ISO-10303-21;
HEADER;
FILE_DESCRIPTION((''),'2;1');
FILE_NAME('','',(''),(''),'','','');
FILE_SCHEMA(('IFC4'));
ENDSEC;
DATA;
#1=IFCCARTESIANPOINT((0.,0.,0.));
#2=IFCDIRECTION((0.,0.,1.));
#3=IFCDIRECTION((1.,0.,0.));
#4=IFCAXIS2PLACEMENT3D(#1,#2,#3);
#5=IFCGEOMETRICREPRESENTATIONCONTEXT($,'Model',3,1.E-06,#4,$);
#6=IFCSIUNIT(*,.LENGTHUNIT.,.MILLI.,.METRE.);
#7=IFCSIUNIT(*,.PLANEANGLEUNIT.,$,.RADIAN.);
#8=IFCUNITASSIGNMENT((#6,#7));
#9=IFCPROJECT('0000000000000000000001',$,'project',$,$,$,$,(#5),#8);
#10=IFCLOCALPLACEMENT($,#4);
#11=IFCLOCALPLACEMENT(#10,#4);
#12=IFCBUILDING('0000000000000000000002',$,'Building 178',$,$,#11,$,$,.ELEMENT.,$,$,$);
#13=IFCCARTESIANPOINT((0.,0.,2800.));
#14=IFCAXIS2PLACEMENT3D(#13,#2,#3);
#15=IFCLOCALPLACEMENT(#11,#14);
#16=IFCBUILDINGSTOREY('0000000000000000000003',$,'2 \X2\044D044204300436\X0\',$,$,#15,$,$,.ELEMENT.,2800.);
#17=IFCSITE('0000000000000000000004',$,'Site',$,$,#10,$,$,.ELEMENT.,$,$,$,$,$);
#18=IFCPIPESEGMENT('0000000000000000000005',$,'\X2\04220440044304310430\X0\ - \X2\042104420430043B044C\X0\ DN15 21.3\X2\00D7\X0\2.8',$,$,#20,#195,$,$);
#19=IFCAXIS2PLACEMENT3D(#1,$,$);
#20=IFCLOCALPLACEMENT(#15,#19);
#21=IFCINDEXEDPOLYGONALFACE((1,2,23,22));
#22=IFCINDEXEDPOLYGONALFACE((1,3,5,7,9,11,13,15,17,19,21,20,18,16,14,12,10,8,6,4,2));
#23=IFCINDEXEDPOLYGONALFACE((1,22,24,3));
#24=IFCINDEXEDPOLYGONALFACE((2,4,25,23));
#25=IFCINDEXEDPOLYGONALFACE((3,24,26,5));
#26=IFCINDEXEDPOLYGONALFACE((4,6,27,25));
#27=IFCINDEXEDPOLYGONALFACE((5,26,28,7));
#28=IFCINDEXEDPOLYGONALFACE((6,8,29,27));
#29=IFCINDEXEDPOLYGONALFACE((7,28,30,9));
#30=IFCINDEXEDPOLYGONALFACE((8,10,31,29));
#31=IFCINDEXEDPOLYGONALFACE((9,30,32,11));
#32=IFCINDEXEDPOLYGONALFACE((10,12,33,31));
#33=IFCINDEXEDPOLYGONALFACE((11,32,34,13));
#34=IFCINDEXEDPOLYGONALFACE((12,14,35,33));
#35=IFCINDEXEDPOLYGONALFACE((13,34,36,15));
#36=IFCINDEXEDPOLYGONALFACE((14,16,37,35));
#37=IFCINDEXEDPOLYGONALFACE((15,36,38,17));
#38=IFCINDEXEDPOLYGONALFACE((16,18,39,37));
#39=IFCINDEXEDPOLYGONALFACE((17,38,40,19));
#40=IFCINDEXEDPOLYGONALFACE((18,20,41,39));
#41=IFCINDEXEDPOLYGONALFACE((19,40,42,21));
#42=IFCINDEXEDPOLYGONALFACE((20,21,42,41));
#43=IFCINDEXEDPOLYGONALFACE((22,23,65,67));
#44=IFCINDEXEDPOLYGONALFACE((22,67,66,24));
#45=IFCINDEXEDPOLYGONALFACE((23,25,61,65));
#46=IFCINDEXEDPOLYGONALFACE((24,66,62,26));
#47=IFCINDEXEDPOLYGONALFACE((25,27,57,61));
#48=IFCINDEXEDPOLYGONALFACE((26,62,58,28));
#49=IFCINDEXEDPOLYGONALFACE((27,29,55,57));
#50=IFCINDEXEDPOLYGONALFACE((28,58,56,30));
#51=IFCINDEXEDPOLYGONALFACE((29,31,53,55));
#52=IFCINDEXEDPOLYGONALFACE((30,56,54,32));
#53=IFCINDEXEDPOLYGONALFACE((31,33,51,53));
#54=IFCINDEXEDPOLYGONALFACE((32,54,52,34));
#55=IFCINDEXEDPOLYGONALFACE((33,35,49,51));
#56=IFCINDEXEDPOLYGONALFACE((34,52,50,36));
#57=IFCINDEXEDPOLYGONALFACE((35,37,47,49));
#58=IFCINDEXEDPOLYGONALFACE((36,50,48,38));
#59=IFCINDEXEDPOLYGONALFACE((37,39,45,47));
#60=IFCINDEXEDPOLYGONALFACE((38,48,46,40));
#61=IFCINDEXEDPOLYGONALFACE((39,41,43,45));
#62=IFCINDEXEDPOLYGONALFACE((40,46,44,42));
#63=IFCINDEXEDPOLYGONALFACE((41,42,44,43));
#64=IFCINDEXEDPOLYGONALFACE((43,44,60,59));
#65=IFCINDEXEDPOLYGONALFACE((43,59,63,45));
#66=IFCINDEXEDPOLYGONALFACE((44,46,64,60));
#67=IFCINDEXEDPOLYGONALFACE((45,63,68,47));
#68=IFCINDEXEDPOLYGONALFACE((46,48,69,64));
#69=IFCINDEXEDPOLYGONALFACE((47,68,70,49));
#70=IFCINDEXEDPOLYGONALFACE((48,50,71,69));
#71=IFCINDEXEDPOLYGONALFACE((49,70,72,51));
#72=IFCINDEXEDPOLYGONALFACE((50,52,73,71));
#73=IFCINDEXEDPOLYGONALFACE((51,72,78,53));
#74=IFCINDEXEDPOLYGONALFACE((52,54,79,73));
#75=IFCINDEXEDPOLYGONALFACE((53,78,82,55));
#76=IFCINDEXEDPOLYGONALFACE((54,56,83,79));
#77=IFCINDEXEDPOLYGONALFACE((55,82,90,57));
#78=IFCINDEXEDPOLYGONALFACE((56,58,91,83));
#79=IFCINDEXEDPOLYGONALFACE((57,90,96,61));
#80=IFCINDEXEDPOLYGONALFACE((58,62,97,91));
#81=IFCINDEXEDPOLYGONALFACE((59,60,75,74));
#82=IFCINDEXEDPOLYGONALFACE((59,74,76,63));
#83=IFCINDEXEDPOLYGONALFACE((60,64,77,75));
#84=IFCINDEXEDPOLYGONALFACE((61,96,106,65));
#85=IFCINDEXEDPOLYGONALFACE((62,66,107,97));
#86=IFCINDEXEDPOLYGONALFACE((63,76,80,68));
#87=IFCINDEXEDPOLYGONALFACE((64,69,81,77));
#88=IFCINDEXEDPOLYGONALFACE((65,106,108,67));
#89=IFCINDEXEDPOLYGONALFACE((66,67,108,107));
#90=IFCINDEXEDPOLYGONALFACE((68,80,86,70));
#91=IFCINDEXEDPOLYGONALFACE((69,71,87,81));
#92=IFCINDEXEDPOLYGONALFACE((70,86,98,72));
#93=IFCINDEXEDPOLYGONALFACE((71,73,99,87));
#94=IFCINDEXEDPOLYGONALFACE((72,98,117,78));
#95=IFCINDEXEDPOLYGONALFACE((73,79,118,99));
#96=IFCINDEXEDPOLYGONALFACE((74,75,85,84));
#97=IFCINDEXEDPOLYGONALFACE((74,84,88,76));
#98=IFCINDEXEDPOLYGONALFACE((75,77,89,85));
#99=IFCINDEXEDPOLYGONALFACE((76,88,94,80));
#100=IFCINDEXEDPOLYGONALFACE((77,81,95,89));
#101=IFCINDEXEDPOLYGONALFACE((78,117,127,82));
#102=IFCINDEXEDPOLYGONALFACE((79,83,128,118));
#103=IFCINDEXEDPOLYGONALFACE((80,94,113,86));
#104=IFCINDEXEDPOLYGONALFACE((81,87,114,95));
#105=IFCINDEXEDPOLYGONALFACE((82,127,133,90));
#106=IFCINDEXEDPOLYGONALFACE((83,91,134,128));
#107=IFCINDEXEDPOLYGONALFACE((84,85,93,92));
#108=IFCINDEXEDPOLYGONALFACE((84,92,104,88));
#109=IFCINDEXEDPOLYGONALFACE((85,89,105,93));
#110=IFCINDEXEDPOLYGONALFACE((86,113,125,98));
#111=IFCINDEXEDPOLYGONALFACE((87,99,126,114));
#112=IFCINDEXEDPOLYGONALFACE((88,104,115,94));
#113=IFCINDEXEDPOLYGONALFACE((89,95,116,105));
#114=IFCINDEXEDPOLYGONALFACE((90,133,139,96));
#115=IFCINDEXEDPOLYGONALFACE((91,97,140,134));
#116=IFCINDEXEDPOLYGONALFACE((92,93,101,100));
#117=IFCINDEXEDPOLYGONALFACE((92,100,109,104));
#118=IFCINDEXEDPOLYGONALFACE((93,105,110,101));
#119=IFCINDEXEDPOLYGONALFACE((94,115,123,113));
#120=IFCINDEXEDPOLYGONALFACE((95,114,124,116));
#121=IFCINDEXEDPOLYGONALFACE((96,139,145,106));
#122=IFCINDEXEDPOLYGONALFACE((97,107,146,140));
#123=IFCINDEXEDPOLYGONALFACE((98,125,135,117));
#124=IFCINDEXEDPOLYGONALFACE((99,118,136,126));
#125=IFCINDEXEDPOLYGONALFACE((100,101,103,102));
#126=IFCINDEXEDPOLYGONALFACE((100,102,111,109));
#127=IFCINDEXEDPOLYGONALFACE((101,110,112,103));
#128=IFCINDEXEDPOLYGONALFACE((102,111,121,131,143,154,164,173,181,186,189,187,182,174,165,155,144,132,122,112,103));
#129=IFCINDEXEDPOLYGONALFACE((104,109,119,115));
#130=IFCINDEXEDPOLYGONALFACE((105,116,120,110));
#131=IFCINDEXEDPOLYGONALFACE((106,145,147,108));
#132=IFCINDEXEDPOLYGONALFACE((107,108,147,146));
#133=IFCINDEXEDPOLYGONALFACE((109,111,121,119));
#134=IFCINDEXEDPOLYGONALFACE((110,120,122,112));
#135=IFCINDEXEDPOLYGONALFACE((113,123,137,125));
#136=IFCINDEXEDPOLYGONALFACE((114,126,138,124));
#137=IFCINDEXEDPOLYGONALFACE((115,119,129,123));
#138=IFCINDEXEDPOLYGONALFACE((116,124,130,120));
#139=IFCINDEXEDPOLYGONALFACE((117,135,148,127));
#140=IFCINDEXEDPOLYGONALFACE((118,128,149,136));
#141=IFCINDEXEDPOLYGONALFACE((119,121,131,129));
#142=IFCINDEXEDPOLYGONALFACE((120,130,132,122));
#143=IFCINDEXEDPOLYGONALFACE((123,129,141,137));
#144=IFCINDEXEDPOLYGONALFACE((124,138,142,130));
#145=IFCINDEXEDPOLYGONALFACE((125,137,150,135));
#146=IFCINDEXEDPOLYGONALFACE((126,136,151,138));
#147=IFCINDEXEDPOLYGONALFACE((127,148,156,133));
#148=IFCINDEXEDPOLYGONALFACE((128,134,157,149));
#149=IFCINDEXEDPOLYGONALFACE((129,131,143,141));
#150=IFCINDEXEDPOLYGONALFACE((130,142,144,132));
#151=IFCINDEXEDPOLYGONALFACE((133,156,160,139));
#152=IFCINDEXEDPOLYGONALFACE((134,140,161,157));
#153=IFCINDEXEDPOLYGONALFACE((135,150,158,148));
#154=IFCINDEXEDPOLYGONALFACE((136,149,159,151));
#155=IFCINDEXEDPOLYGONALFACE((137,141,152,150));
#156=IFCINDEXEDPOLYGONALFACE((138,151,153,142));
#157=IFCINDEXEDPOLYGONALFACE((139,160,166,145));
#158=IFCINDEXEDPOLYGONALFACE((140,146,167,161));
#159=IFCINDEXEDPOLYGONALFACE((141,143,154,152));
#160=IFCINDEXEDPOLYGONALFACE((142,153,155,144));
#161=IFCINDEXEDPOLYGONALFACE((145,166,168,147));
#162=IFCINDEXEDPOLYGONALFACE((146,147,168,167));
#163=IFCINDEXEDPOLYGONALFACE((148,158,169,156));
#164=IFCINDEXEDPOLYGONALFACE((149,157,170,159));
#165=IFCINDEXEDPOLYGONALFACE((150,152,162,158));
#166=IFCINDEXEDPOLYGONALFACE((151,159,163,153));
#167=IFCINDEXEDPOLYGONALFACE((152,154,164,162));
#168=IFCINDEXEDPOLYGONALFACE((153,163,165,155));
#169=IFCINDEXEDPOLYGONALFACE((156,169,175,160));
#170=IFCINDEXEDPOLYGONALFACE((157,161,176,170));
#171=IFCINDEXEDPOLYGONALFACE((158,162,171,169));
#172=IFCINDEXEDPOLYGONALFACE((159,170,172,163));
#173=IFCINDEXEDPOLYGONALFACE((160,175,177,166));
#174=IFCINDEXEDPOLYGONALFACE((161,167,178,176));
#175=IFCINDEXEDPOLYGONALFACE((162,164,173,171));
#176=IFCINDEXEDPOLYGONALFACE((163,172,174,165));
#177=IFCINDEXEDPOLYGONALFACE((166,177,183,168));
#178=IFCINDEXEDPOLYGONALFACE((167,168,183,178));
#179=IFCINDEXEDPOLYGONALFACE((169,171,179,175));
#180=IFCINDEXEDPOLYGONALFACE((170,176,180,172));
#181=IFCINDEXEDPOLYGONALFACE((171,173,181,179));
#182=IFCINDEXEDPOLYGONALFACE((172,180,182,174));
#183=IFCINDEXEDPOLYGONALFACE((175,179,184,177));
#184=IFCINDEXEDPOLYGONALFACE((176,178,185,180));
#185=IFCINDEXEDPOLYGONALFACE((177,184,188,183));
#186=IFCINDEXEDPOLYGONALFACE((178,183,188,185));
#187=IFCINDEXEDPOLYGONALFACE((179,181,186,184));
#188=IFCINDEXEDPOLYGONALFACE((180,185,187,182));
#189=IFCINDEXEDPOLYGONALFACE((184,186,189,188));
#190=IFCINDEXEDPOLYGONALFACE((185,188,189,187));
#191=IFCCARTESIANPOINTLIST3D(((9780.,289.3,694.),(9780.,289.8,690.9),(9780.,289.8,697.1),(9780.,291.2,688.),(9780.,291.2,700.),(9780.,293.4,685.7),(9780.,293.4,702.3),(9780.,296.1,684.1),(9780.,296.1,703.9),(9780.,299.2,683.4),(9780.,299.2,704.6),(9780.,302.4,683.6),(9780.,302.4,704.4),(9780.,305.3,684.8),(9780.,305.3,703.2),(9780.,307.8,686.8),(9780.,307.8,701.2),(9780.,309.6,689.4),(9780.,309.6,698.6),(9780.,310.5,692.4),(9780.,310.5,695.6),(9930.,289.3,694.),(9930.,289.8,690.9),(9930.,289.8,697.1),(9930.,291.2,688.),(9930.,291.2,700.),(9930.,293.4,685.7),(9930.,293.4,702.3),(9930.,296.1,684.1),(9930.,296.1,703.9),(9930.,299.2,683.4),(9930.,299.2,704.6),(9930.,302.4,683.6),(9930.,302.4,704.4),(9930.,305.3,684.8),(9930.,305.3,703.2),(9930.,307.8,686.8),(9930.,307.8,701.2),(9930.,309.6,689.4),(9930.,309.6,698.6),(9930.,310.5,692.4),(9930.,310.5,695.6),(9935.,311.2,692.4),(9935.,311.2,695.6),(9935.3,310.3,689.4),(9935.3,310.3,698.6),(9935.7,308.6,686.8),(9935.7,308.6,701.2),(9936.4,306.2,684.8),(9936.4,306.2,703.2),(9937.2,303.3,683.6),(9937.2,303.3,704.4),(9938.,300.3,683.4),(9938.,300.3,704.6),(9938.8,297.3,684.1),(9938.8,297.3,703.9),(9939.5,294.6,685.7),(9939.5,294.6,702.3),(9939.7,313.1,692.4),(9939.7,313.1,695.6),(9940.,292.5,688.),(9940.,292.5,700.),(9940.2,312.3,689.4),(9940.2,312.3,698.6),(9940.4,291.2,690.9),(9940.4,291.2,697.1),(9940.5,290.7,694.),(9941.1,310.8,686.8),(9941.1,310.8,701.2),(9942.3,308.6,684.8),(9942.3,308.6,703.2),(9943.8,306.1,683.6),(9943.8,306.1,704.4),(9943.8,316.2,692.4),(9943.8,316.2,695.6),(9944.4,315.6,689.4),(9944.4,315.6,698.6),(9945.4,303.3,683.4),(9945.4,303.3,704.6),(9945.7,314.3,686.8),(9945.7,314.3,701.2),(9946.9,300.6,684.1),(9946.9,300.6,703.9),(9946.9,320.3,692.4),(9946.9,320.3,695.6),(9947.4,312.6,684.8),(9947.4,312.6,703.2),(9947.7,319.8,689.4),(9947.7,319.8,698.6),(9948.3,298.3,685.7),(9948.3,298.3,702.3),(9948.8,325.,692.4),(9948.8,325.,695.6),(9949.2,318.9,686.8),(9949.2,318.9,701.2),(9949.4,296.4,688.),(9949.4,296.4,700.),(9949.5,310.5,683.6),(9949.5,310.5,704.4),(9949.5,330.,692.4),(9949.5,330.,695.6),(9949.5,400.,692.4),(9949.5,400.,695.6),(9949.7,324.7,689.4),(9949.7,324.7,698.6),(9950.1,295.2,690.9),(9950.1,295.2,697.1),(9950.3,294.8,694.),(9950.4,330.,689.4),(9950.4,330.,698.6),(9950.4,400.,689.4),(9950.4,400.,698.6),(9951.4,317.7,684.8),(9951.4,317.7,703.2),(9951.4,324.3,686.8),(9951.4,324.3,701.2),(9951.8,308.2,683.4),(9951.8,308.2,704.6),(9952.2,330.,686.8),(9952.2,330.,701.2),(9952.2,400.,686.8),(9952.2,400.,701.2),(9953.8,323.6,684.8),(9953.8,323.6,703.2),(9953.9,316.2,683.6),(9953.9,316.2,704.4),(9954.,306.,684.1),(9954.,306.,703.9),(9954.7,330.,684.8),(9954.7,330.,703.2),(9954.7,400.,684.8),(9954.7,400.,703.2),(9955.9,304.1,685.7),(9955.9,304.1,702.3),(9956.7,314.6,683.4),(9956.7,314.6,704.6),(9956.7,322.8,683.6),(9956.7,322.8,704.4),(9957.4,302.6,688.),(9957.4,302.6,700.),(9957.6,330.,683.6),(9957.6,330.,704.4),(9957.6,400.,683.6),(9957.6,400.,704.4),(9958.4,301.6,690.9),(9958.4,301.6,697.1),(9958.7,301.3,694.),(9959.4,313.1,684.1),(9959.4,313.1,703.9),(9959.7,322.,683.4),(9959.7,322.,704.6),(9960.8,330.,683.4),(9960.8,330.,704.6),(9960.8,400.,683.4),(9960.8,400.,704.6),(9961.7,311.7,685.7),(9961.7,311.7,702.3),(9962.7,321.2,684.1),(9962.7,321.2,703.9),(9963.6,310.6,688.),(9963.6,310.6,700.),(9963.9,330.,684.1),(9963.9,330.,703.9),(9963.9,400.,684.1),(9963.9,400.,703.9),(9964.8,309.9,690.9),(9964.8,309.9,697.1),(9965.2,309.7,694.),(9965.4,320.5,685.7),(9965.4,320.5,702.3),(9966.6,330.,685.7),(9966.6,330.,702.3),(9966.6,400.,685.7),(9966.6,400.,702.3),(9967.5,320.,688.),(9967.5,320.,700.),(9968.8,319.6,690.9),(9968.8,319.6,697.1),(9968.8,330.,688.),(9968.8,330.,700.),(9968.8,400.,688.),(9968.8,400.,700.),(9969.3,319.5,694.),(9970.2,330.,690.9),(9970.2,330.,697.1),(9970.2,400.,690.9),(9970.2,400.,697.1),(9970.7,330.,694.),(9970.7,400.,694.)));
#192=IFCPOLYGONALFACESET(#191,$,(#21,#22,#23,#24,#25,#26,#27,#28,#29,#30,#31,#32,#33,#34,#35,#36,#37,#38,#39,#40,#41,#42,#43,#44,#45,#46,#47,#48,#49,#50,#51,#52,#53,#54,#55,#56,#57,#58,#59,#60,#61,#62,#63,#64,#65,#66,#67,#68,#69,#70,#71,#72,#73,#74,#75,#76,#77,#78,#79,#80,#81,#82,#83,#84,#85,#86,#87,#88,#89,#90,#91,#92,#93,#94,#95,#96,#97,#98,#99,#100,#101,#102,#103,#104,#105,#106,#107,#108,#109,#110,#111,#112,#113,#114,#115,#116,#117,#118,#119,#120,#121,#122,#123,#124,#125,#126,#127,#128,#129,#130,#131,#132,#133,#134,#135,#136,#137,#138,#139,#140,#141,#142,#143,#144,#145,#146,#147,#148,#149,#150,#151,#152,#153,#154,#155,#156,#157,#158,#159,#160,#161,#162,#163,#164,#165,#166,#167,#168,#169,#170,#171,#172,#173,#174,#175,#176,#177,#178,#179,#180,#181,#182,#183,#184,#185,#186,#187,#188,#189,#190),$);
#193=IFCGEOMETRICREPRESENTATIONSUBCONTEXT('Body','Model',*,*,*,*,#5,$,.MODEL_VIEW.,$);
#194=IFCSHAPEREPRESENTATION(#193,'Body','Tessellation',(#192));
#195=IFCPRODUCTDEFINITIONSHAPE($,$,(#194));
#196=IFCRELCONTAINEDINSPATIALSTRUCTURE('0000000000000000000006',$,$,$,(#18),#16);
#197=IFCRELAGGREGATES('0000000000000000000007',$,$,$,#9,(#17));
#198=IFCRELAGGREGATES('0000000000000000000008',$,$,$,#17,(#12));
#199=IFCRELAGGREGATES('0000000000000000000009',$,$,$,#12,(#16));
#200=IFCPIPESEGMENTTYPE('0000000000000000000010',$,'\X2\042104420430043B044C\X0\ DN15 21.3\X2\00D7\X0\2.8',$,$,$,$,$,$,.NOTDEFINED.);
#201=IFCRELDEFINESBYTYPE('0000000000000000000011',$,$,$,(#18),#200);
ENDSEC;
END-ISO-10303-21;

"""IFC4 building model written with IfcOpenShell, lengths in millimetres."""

from ifc_helpers import new_model, entity, si_unit, frame, origin_with_axes, place, context, subcontext, project, spatial, source, transform, mapped, type_object, element, save


model = new_model("IFC4")

# Units and contexts
model_context = context("Model", 3, precision=1e-06, world=origin_with_axes())
body_context = subcontext(model_context, "Body", "Model", "MODEL_VIEW")
ifc_project = project(units=[si_unit("LENGTHUNIT", "METRE", prefix="MILLI"), si_unit("PLANEANGLEUNIT", "RADIAN")], contexts=[model_context])

# Site, building, storey
site_placement = place(None, origin_with_axes())
site = spatial("IfcSite", under=ifc_project, at=site_placement, Name="Site", CompositionType="ELEMENT")
building_placement = place(site_placement, origin_with_axes())
building = spatial("IfcBuilding", under=site, at=building_placement, Name="Building 178", CompositionType="ELEMENT")
storey_placement = place(building_placement, frame((0.0, 0.0, 2800.0), z_axis=(0.0, 0.0, 1.0), x_axis=(1.0, 0.0, 0.0)))
storey = spatial("IfcBuildingStorey", under=building, at=storey_placement, Name="2 этаж", CompositionType="ELEMENT", Elevation=2800.0)

# Pipe segment
pipe_segment_type = type_object("IfcPipeSegmentType", Name="Сталь DN15 21.3×2.8", PredefinedType="NOTDEFINED")
shared_shape_1 = source(origin_with_axes(), body_context, "Body", "AdvancedSweptSolid", [
    entity("IfcSweptDiskSolid", entity("IfcIndexedPolyCurve", entity("IfcCartesianPointList3D", [[0.0, 0.0, 0.0], [0.0, 0.0, -70.0], [8.8, 0.0, -91.2], [30.0, 0.0, -100.0], [180.0, 0.0, -100.0]]), [entity("IfcLineIndex", [1, 2]), entity("IfcArcIndex", [2, 3, 4]), entity("IfcLineIndex", [4, 5])]), 10.7),
])
for number, where, z_axis, x_axis, name in (
    (1, (9960.0, 400.0, 694.0), (0.0, 1.0, 0.0), (-1.0, 0.0, 0.0), "Труба - Сталь DN15 21.3×2.8"),
):
    element("IfcPipeSegment", number, at=place(storey_placement, frame(where, z_axis=z_axis, x_axis=x_axis)), inside=storey, type_object=pipe_segment_type, Name=name, context=body_context, shape_type="MappedRepresentation", body=[
        mapped(shared_shape_1, transform((0.0, 0.0, 0.0), x_axis=(1.0, 0.0, 0.0), y_axis=(0.0, 1.0, 0.0), z_axis=(0.0, 0.0, 1.0), scale=1.0)),
    ])

save(model, "model.ifc")
